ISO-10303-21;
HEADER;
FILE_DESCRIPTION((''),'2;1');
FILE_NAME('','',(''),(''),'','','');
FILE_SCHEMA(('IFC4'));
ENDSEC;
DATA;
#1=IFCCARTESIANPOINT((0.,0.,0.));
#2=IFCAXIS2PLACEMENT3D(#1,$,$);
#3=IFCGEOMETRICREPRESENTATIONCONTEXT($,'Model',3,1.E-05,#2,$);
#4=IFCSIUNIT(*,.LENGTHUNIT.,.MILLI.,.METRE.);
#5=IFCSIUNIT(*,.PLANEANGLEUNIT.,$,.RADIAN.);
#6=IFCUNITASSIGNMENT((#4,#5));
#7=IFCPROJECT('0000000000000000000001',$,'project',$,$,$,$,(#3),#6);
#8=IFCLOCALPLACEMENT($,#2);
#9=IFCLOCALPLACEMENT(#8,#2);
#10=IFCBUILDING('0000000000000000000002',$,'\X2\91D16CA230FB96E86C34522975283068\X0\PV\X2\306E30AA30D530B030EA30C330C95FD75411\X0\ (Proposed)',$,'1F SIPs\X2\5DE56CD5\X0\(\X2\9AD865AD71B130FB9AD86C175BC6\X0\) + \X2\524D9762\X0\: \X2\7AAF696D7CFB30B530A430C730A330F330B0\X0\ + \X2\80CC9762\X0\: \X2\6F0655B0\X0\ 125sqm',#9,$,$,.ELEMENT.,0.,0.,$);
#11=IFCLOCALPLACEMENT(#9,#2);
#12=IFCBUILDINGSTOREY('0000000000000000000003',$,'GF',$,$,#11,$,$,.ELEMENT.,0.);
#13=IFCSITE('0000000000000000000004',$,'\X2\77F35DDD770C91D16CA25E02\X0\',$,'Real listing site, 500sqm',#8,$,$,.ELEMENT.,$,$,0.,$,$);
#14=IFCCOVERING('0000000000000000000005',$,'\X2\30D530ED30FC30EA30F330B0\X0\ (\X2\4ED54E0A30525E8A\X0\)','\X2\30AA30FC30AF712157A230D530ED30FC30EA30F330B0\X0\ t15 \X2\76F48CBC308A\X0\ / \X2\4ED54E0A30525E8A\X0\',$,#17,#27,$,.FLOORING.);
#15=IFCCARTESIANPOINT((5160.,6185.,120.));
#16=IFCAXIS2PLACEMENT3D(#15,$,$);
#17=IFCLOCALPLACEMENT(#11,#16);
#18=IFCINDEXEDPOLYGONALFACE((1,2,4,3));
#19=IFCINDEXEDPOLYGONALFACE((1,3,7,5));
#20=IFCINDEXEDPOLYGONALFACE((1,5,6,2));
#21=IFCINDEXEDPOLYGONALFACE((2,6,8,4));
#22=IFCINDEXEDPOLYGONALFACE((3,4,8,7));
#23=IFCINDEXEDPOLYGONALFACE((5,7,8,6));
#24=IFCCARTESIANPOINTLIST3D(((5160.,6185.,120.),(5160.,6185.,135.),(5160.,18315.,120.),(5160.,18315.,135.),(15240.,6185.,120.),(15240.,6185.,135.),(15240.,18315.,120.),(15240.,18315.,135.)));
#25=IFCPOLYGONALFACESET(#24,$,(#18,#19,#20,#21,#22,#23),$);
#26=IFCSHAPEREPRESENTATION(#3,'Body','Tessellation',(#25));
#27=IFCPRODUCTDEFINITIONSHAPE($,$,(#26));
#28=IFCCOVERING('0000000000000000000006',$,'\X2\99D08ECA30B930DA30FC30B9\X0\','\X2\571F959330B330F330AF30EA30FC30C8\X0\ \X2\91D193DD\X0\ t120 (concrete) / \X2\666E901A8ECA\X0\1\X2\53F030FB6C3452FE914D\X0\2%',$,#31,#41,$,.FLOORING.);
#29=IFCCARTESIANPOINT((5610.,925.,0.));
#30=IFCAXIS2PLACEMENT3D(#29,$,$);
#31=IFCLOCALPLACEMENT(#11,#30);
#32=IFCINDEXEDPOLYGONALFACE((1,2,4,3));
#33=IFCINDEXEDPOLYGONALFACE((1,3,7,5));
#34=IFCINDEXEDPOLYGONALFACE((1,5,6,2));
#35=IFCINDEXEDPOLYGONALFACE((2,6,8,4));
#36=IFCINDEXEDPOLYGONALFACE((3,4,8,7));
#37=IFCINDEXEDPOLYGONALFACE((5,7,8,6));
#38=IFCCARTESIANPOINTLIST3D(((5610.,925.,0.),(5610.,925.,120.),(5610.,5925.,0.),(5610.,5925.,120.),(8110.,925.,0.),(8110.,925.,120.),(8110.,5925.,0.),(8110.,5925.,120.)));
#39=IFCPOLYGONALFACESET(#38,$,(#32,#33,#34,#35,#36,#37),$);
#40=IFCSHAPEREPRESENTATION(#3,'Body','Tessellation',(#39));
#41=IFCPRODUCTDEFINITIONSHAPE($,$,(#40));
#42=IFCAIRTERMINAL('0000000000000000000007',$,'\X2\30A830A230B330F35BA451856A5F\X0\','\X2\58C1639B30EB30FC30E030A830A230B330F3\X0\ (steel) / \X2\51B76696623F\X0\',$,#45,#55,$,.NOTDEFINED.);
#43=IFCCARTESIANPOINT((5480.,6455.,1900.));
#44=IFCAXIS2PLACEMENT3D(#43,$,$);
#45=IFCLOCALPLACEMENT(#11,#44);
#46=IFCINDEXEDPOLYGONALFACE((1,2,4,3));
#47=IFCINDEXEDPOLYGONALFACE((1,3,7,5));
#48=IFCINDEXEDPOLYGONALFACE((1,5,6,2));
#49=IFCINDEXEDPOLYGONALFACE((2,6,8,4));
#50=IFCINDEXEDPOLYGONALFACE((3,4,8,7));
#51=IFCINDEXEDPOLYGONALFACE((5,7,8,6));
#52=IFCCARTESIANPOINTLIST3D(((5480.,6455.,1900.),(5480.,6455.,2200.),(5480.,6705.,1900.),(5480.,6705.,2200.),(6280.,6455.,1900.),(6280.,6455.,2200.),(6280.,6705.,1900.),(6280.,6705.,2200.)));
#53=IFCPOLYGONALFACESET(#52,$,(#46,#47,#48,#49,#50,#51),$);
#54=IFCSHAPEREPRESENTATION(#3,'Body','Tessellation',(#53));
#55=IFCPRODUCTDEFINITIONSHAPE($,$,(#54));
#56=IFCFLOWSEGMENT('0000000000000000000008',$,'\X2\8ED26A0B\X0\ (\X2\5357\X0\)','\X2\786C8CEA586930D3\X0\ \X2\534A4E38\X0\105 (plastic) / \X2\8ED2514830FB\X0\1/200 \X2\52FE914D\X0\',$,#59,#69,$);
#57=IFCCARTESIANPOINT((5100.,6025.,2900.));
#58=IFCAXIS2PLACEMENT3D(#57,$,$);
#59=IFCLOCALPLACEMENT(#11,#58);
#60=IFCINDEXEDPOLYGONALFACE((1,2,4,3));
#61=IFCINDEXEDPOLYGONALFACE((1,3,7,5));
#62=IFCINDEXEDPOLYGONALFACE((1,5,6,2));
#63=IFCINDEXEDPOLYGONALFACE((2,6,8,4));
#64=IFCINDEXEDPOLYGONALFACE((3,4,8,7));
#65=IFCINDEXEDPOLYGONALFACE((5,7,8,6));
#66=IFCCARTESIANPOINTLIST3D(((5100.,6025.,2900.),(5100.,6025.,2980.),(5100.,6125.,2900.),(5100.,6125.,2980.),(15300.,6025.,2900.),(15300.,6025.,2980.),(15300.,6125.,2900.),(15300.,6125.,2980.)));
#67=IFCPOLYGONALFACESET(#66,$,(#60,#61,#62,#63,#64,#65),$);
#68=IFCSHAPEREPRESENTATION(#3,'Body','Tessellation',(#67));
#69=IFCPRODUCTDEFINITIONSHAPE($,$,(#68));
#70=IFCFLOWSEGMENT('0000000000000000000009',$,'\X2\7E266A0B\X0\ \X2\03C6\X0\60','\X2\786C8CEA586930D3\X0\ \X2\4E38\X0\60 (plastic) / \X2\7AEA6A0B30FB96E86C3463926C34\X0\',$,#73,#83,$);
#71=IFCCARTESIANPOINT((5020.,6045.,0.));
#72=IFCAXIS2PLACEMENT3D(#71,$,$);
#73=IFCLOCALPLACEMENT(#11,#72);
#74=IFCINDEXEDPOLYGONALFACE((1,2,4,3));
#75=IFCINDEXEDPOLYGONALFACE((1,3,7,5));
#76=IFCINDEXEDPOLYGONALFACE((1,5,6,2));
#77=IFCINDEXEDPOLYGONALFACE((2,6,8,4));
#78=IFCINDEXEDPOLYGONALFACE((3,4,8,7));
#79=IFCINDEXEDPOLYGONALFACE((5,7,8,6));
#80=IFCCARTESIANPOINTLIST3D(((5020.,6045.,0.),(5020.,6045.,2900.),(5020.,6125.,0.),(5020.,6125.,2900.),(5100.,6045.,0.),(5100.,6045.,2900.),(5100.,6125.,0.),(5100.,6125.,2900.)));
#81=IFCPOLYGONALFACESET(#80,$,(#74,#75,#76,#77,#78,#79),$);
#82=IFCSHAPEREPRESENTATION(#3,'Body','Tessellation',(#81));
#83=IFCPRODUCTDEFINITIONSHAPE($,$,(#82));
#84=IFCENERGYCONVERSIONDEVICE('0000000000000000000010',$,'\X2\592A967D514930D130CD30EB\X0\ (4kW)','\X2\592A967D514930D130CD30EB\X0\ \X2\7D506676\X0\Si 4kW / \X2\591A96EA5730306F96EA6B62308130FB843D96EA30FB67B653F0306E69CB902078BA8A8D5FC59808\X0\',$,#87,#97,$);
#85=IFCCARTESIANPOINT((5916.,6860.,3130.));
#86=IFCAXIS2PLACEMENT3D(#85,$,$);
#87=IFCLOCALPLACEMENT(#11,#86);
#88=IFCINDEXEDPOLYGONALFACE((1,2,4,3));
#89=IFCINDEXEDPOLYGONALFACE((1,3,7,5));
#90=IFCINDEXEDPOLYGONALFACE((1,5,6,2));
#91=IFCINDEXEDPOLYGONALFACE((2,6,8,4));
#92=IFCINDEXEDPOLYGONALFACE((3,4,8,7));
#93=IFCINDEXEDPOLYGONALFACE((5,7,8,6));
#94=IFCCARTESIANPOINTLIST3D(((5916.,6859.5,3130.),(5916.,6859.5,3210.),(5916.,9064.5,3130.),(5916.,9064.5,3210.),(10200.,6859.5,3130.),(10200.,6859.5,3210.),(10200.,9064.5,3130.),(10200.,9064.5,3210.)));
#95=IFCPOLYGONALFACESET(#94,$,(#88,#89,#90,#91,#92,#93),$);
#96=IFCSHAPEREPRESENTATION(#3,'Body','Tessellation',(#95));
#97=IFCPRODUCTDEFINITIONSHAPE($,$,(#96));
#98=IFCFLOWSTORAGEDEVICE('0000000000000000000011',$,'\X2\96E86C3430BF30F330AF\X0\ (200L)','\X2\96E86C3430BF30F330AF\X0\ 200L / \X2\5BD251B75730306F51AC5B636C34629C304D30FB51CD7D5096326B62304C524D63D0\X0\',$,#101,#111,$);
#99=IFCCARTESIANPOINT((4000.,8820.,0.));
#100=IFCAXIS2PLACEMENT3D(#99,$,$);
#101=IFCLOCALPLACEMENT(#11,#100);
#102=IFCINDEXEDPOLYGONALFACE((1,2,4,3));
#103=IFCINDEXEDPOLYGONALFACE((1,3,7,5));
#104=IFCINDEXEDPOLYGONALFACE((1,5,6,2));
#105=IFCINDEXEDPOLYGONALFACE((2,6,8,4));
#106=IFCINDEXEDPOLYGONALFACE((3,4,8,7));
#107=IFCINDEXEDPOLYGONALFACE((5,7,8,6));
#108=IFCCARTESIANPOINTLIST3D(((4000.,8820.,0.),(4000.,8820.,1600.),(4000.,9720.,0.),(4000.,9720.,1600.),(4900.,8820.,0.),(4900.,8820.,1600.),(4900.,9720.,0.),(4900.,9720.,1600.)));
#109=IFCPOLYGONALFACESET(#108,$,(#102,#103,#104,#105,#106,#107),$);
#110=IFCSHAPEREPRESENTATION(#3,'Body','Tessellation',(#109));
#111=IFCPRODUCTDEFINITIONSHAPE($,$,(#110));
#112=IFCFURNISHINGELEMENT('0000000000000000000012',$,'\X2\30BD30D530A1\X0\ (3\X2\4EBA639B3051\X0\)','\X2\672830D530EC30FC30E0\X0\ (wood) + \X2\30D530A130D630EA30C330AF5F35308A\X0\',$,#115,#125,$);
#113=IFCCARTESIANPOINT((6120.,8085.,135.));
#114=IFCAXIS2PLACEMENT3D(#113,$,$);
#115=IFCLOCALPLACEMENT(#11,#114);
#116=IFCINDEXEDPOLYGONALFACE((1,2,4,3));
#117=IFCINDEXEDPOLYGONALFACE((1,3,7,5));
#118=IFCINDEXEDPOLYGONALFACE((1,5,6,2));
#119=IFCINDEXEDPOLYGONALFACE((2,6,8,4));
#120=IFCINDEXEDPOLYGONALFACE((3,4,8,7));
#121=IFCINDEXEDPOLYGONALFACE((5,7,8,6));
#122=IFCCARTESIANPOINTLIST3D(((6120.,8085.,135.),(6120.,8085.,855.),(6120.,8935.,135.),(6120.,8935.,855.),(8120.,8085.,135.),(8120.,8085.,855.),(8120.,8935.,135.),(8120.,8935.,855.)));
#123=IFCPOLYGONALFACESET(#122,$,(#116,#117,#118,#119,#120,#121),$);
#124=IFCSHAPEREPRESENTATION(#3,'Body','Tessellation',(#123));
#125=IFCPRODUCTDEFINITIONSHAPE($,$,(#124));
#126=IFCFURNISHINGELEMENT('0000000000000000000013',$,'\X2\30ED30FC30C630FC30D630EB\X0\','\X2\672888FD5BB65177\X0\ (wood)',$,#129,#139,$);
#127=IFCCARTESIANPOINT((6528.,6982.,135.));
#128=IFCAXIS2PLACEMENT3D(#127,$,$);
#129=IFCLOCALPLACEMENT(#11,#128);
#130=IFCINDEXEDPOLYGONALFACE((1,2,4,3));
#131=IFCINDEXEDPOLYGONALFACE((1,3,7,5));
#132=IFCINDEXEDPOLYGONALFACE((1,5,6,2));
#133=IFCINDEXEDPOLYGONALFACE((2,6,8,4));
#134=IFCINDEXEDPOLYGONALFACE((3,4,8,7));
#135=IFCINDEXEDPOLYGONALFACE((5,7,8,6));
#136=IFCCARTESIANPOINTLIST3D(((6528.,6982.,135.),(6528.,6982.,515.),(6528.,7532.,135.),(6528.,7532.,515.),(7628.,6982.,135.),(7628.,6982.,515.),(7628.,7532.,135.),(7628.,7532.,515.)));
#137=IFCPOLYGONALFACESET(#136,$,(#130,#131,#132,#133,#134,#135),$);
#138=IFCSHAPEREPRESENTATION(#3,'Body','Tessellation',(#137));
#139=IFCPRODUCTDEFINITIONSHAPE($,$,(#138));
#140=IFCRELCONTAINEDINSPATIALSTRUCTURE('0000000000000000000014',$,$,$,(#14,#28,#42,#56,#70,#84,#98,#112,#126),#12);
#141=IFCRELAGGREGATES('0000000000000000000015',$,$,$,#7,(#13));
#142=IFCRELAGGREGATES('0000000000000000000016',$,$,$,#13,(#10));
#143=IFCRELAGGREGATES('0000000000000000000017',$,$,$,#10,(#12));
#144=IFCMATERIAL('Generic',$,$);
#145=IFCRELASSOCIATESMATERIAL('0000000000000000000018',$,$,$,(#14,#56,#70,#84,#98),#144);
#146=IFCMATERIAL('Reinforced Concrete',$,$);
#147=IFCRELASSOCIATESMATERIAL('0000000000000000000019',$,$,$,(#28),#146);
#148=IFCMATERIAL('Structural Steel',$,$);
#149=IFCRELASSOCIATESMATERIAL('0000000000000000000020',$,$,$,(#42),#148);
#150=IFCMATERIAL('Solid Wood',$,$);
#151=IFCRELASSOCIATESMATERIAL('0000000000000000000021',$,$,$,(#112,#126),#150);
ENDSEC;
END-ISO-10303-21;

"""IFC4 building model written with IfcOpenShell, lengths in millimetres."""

from ifc_helpers import new_model, si_unit, frame, frame_2d, origin, place, context, project, spatial, rectangle, extrude, material, element, save


model = new_model("IFC4")

# Units and contexts
model_context = context("Model", 3, precision=1e-05, world=origin())
ifc_project = project(units=[si_unit("LENGTHUNIT", "METRE", prefix="MILLI"), si_unit("PLANEANGLEUNIT", "RADIAN")], contexts=[model_context])

# Site, building, storey
site_placement = place(None, origin())
site = spatial("IfcSite", under=ifc_project, at=site_placement, Name="石川県金沢市", ObjectType="Real listing site, 500sqm", CompositionType="ELEMENT", RefElevation=0.0)
building_placement = place(site_placement, origin())
building = spatial("IfcBuilding", under=site, at=building_placement, Name="金沢・雨水利用とPVのオフグリッド志向 (Proposed)", ObjectType="1F SIPs工法(高断熱・高気密) + 前面: 窯業系サイディング + 背面: 漆喰 125sqm", CompositionType="ELEMENT", ElevationOfRefHeight=0.0, ElevationOfTerrain=0.0)
storey_placement = place(building_placement, origin())
storey = spatial("IfcBuildingStorey", under=building, at=storey_placement, Name="GF", CompositionType="ELEMENT", Elevation=0.0)

# Shared definitions
ifc_material_1 = material(Name="Solid Wood")

# Shared definitions
ifc_material_2 = material(Name="Reinforced Concrete")

# Shared definitions
ifc_material_3 = material(Name="Structural Steel")

# Coverings
ifc_material_4 = material(Name="Generic")
covering_1_placement = place(storey_placement, frame((5160.0, 6185.0, 120.0)))
element("IfcCovering", 1, at=covering_1_placement, inside=storey, material=ifc_material_4, Name="フローリング (仕上げ床)", Description="オーク無垢フローリング t15 直貼り / 仕上げ床", PredefinedType="FLOORING", context=model_context, shape_type="SweptSolid", body=[
    extrude(rectangle(XDim=10080.0, YDim=12130.0, at=frame_2d((5040.0, 6065.0))), frame((5160.0, 6185.0, 120.0)), (0.0, 0.0, 1.0), 15.0),
])
covering_2_placement = place(storey_placement, frame((5610.0, 925.0, 0.0)))
element("IfcCovering", 2, at=covering_2_placement, inside=storey, material=ifc_material_2, Name="駐車スペース", Description="土間コンクリート 金鏝 t120 (concrete) / 普通車1台・水勾配2%", PredefinedType="FLOORING", context=model_context, shape_type="SweptSolid", body=[
    extrude(rectangle(XDim=2500.0, YDim=5000.0, at=frame_2d((1250.0, 2500.0))), frame((5610.0, 925.0, 0.0)), (0.0, 0.0, 1.0), 120.0),
])

# Air terminal
air_terminal_placement = place(storey_placement, frame((5480.0, 6455.0, 1900.0)))
element("IfcAirTerminal", 3, at=air_terminal_placement, inside=storey, material=ifc_material_3, Name="エアコン室内機", Description="壁掛ルームエアコン (steel) / 冷暖房", PredefinedType="NOTDEFINED", context=model_context, shape_type="SweptSolid", body=[
    extrude(rectangle(XDim=800.0, YDim=250.0, at=frame_2d((400.0, 125.0))), frame((5480.0, 6455.0, 1900.0)), (0.0, 0.0, 1.0), 300.0),
])

# Flow segments
flow_segment_1_placement = place(storey_placement, frame((5100.0, 6025.0, 2900.0)))
element("IfcFlowSegment", 4, at=flow_segment_1_placement, inside=storey, material=ifc_material_4, Name="軒樋 (南)", Description="硬質塩ビ 半丸105 (plastic) / 軒先・1/200 勾配", context=model_context, shape_type="SweptSolid", body=[
    extrude(rectangle(XDim=10200.0, YDim=100.0, at=frame_2d((5100.0, 50.0))), frame((5100.0, 6025.0, 2900.0)), (0.0, 0.0, 1.0), 80.0),
])
flow_segment_2_placement = place(storey_placement, frame((5020.0, 6045.0, 0.0)))
element("IfcFlowSegment", 5, at=flow_segment_2_placement, inside=storey, material=ifc_material_4, Name="縦樋 φ60", Description="硬質塩ビ 丸60 (plastic) / 竪樋・雨水排水", context=model_context, shape_type="SweptSolid", body=[
    extrude(rectangle(XDim=80.0, YDim=80.0, at=frame_2d((40.0, 40.0))), frame((5020.0, 6045.0, 0.0)), (0.0, 0.0, 1.0), 2900.0),
])

# Energy conversion device
energy_conversion_device_placement = place(storey_placement, frame((5916.0, 6860.0, 3130.0)))
element("IfcEnergyConversionDevice", 6, at=energy_conversion_device_placement, inside=storey, material=ifc_material_4, Name="太陽光パネル (4kW)", Description="太陽光パネル 結晶Si 4kW / 多雪地は雪止め・落雪・架台の構造確認必須", context=model_context, shape_type="SweptSolid", body=[
    extrude(rectangle(XDim=4284.0, YDim=2205.0, at=frame_2d((2142.0, 1102.0))), frame((5916.0, 6860.0, 3130.0)), (0.0, 0.0, 1.0), 80.0),
])

# Flow storage device
flow_storage_device_placement = place(storey_placement, frame((4000.0, 8820.0, 0.0)))
element("IfcFlowStorageDevice", 7, at=flow_storage_device_placement, inside=storey, material=ifc_material_4, Name="雨水タンク (200L)", Description="雨水タンク 200L / 寒冷地は冬季水抜き・凍結防止が前提", context=model_context, shape_type="SweptSolid", body=[
    extrude(rectangle(XDim=900.0, YDim=900.0, at=frame_2d((450.0, 450.0))), frame((4000.0, 8820.0, 0.0)), (0.0, 0.0, 1.0), 1600.0),
])

# Furnishing elements
furnishing_1_placement = place(storey_placement, frame((6120.0, 8085.0, 135.0)))
element("IfcFurnishingElement", 8, at=furnishing_1_placement, inside=storey, material=ifc_material_1, Name="ソファ (3人掛け)", Description="木フレーム (wood) + ファブリック張り", context=model_context, shape_type="SweptSolid", body=[
    extrude(rectangle(XDim=2000.0, YDim=850.0, at=frame_2d((1000.0, 425.0))), frame((6120.0, 8085.0, 135.0)), (0.0, 0.0, 1.0), 720.0),
])
furnishing_2_placement = place(storey_placement, frame((6528.0, 6982.0, 135.0)))
element("IfcFurnishingElement", 9, at=furnishing_2_placement, inside=storey, material=ifc_material_1, Name="ローテーブル", Description="木製家具 (wood)", context=model_context, shape_type="SweptSolid", body=[
    extrude(rectangle(XDim=1100.0, YDim=550.0, at=frame_2d((550.0, 275.0))), frame((6528.0, 6982.0, 135.0)), (0.0, 0.0, 1.0), 380.0),
])

save(model, "model.ifc")
